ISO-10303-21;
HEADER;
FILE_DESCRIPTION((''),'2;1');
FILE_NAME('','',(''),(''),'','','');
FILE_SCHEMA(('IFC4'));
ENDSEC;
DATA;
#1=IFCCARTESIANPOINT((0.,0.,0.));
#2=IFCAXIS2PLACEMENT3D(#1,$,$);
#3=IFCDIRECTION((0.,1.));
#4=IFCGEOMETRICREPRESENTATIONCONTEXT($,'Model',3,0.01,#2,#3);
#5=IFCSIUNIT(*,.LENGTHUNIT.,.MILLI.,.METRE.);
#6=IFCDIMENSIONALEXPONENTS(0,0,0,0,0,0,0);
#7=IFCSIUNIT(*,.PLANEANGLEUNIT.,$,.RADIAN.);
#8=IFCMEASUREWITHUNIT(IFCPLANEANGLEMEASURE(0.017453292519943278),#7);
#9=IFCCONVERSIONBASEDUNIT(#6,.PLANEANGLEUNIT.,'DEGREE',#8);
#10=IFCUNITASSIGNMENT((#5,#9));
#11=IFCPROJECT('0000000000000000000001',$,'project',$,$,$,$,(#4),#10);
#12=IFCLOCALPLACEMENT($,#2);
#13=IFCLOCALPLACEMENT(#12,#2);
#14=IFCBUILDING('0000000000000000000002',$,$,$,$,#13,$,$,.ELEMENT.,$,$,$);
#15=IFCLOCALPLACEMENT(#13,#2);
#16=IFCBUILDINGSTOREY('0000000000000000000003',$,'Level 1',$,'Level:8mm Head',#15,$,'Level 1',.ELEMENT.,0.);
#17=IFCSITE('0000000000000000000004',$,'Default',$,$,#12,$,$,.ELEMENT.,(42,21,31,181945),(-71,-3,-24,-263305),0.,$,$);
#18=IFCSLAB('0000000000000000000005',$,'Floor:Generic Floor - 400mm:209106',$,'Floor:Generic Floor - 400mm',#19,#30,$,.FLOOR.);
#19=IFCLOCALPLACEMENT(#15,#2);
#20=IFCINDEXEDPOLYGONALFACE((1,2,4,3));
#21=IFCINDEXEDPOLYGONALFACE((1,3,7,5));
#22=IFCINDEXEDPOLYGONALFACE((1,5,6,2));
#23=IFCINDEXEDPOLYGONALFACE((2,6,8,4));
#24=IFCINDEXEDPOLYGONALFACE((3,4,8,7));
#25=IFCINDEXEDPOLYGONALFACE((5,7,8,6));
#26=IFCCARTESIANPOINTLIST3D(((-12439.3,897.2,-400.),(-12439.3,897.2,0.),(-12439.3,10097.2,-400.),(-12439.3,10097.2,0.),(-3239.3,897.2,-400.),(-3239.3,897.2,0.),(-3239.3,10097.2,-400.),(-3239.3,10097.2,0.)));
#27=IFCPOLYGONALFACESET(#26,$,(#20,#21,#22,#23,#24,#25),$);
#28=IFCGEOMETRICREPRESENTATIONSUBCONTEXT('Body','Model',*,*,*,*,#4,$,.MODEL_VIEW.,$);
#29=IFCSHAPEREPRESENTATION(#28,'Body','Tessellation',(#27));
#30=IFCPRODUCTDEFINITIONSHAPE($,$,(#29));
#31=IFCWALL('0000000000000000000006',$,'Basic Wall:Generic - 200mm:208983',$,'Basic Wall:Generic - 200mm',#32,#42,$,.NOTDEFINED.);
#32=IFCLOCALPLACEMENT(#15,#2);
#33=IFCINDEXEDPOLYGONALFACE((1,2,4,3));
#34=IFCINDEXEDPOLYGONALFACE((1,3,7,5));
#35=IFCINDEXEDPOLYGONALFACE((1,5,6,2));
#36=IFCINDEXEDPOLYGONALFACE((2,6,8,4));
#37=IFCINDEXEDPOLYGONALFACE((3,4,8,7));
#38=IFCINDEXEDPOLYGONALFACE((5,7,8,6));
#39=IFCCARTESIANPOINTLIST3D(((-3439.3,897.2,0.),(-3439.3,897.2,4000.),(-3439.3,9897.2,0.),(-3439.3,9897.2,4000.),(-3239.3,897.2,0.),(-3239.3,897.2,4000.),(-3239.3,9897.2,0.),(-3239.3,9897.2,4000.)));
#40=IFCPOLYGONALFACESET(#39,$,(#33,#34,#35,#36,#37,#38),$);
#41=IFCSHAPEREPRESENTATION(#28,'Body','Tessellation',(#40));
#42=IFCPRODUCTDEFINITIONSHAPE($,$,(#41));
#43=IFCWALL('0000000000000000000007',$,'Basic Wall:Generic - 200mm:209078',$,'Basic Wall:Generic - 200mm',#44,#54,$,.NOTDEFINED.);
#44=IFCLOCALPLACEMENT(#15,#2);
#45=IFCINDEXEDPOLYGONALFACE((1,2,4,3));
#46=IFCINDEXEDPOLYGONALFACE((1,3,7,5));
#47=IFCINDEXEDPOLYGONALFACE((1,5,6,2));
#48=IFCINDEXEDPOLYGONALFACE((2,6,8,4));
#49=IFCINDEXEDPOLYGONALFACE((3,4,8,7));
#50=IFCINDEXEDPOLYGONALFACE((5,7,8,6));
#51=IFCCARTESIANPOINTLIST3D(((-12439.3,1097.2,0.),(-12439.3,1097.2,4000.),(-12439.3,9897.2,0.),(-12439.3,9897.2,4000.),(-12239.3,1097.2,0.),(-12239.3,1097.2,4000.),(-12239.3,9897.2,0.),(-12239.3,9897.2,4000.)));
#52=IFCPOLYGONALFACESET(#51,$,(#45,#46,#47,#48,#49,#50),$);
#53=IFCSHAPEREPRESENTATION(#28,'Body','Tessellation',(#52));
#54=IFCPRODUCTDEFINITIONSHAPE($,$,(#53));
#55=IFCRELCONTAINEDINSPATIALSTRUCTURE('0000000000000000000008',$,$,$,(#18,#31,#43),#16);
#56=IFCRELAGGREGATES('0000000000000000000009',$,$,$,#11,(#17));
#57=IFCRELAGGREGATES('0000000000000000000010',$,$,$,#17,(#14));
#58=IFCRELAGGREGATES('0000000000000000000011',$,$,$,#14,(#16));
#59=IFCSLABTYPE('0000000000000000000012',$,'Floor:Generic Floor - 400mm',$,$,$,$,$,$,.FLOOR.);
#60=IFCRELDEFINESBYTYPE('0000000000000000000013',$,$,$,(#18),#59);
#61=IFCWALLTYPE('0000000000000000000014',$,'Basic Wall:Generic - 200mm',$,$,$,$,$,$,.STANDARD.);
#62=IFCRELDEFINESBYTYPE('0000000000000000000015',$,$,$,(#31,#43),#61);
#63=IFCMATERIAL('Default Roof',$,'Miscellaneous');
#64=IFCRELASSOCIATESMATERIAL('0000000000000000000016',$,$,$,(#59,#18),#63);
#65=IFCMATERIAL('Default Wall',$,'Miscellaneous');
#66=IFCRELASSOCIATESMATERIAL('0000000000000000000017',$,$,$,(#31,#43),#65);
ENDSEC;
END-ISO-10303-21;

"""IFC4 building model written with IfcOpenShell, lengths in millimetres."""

from ifc_helpers import new_model, entity, si_unit, converted_unit, direction, frame, origin, place, context, subcontext, project, spatial, indexed_curve, outline, extrude, material, type_object, element, save


model = new_model("IFC4")

# Units and contexts
model_context = context("Model", 3, precision=0.01, world=origin(), true_north=direction((0.0, 1.0)))
body_context = subcontext(model_context, "Body", "Model", "MODEL_VIEW")
ifc_project = project(units=[si_unit("LENGTHUNIT", "METRE", prefix="MILLI"), converted_unit("PLANEANGLEUNIT", "DEGREE", entity("IfcPlaneAngleMeasure", 0.017453292519943278), si_unit("PLANEANGLEUNIT", "RADIAN"), dimensions=[0, 0, 0, 0, 0, 0, 0])], contexts=[model_context])

# Site, building, storey
site_placement = place(None, origin())
site = spatial("IfcSite", under=ifc_project, at=site_placement, Name="Default", CompositionType="ELEMENT", RefLatitude=(42, 21, 31, 181945), RefLongitude=(-71, -3, -24, -263305), RefElevation=0.0)
building_placement = place(site_placement, origin())
building = spatial("IfcBuilding", under=site, at=building_placement, CompositionType="ELEMENT")
storey_placement = place(building_placement, origin())
storey = spatial("IfcBuildingStorey", under=building, at=storey_placement, Name="Level 1", ObjectType="Level:8mm Head", LongName="Level 1", CompositionType="ELEMENT", Elevation=0.0)

# Slab
ifc_material_1 = material(Name="Default Roof", Category="Miscellaneous")
slab_type = type_object("IfcSlabType", Name="Floor:Generic Floor - 400mm", PredefinedType="FLOOR", material=ifc_material_1)
slab_placement = place(storey_placement, origin())
element("IfcSlab", 1, at=slab_placement, inside=storey, type_object=slab_type, material=ifc_material_1, Name="Floor:Generic Floor - 400mm:209106", ObjectType="Floor:Generic Floor - 400mm", PredefinedType="FLOOR", context=body_context, shape_type="SweptSolid", body=[
    extrude(outline(indexed_curve([(-4600.0, -4600.0), (4600.0, -4600.0), (4600.0, 4600.0), (-4600.0, 4600.0), (-4600.0, -4600.0)], self_intersect=False)), frame((-7839.3, 5497.2, 0.0), z_axis=(0.0, 0.0, -1.0), x_axis=(0.0, 1.0, 0.0)), (0.0, 0.0, 1.0), 400.0),
])

# Walls
ifc_material_2 = material(Name="Default Wall", Category="Miscellaneous")
wall_type = type_object("IfcWallType", Name="Basic Wall:Generic - 200mm", PredefinedType="STANDARD")
wall_1_placement = place(storey_placement, frame((-3339.3, 9897.2, 0.0), z_axis=(0.0, 0.0, 1.0), x_axis=(0.0, -1.0, 0.0)))
element("IfcWall", 2, at=wall_1_placement, inside=storey, type_object=wall_type, material=ifc_material_2, Name="Basic Wall:Generic - 200mm:208983", ObjectType="Basic Wall:Generic - 200mm", PredefinedType="NOTDEFINED", context=body_context, shape_type="SweptSolid", body=[
    extrude(outline(indexed_curve([(9000.0, 100.0), (0.0, 100.0), (0.0, -100.0), (9000.0, -100.0), (9000.0, 100.0)], self_intersect=False)), origin(), (0.0, 0.0, 1.0), 4000.0),
])
wall_2_placement = place(storey_placement, frame((-12339.3, 1097.2, 0.0), z_axis=(0.0, 0.0, 1.0), x_axis=(0.0, 1.0, 0.0)))
element("IfcWall", 3, at=wall_2_placement, inside=storey, type_object=wall_type, material=ifc_material_2, Name="Basic Wall:Generic - 200mm:209078", ObjectType="Basic Wall:Generic - 200mm", PredefinedType="NOTDEFINED", context=body_context, shape_type="SweptSolid", body=[
    extrude(outline(indexed_curve([(8800.0, 100.0), (0.0, 100.0), (0.0, -100.0), (8800.0, -100.0), (8800.0, 100.0)], self_intersect=False)), origin(), (0.0, 0.0, 1.0), 4000.0),
])

save(model, "model.ifc")
